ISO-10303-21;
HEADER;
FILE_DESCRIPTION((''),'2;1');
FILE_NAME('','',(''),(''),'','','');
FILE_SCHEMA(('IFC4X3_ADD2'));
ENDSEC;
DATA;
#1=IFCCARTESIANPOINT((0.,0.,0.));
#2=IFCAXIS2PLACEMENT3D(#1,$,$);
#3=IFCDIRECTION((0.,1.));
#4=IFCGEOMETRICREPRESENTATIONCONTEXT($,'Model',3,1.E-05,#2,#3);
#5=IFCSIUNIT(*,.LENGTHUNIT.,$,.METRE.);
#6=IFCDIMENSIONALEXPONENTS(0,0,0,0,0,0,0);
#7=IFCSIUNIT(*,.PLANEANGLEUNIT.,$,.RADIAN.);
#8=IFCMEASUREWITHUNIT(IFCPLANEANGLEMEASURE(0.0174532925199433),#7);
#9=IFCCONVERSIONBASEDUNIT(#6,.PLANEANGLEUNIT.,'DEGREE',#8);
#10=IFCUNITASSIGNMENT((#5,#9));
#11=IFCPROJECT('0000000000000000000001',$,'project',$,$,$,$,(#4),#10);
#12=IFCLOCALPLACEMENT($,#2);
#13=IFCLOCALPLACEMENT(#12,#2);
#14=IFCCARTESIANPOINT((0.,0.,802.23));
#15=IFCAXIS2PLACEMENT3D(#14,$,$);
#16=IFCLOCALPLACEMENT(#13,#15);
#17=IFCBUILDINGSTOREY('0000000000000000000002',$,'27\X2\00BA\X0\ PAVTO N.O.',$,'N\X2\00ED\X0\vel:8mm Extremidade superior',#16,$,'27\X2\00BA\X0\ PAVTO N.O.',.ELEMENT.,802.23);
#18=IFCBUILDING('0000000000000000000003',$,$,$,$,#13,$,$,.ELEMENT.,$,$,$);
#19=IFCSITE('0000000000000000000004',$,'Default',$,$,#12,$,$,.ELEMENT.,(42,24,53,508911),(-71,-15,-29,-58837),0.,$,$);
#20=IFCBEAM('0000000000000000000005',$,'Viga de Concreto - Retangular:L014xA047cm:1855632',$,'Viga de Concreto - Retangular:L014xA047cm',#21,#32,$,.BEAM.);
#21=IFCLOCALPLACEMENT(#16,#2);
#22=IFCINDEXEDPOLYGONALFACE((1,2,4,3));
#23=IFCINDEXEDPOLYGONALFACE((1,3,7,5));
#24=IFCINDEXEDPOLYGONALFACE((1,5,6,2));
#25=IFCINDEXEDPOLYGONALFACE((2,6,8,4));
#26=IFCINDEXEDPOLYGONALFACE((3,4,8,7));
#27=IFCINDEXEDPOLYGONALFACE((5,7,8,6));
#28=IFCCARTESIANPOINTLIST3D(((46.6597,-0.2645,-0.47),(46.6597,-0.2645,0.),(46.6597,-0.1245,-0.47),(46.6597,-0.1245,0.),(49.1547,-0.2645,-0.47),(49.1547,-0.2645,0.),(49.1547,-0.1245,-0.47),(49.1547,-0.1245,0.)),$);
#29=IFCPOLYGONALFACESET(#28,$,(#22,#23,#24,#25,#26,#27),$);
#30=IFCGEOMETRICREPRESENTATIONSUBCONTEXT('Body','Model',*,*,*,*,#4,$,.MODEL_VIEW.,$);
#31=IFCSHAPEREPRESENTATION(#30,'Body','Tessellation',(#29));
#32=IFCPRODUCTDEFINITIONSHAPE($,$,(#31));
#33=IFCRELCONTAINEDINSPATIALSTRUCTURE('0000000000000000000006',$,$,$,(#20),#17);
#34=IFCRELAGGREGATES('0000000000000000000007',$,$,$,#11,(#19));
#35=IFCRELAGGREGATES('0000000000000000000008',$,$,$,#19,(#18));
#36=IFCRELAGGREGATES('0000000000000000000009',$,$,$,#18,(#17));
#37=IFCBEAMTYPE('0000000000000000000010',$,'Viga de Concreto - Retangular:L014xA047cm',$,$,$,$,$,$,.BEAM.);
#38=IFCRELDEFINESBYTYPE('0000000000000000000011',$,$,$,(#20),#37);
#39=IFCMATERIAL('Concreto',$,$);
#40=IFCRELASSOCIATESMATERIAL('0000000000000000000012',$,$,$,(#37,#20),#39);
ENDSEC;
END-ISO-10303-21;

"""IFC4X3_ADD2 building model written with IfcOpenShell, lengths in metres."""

from ifc_helpers import new_model, entity, si_unit, converted_unit, direction, frame, frame_2d, origin, place, context, subcontext, project, spatial, rectangle, extrude, source, transform, mapped, material, material_profile, profile_set, profile_usage, type_object, type_shapes, element, save


model = new_model("IFC4X3_ADD2")

# Units and contexts
model_context = context("Model", 3, precision=1e-05, world=origin(), true_north=direction((0.0, 1.0)))
body_context = subcontext(model_context, "Body", "Model", "MODEL_VIEW")
ifc_project = project(units=[si_unit("LENGTHUNIT", "METRE"), converted_unit("PLANEANGLEUNIT", "DEGREE", entity("IfcPlaneAngleMeasure", 0.0174532925199433), si_unit("PLANEANGLEUNIT", "RADIAN"), dimensions=[0, 0, 0, 0, 0, 0, 0])], contexts=[model_context])

# Site, building, storey
site_placement = place(None, origin())
site = spatial("IfcSite", under=ifc_project, at=site_placement, Name="Default", CompositionType="ELEMENT", RefLatitude=(42, 24, 53, 508911), RefLongitude=(-71, -15, -29, -58837), RefElevation=0.0)
building_placement = place(site_placement, origin())
building = spatial("IfcBuilding", under=site, at=building_placement, CompositionType="ELEMENT")
storey_placement = place(building_placement, frame((0.0, 0.0, 802.23)))
storey = spatial("IfcBuildingStorey", under=building, at=storey_placement, Name="27º PAVTO N.O.", ObjectType="Nível:8mm Extremidade superior", LongName="27º PAVTO N.O.", CompositionType="ELEMENT", Elevation=802.23)

# Beam
ifc_material = material(Name="Concreto")
ifc_material_profile_1 = material_profile(ifc_material, rectangle(XDim=0.47, YDim=0.14, at=frame_2d((0.0, 0.0), x_axis=(0.0, 1.0))), Name="L014xA047cm")
ifc_profile_set_1 = profile_set([ifc_material_profile_1], Name="L014xA047cm")
ifc_profile_usage_1 = profile_usage(ifc_profile_set_1, cardinal=8)
beam_type_1 = type_object("IfcBeamType", Name="Viga de Concreto - Retangular:L014xA047cm", PredefinedType="BEAM", material=ifc_profile_set_1)
shared_shape_1 = source(origin(), body_context, "Body", "SweptSolid", [
    extrude(rectangle(XDim=0.47, YDim=0.14, at=frame_2d((0.0, 0.0), x_axis=(1.0, 0.0))), frame((46.6597, -0.1945, 801.995), z_axis=(1.0, 0.0, 0.0), x_axis=(0.0, 0.0, -1.0)), (0.0, 0.0, 1.0), 2.495),
])
type_shapes(beam_type_1, [shared_shape_1])
beam_1_placement = place(storey_placement, frame((0.0, 0.0, -802.23)))
element("IfcBeam", 1, at=beam_1_placement, inside=storey, type_object=beam_type_1, material=ifc_profile_usage_1, Name="Viga de Concreto - Retangular:L014xA047cm:1855632", ObjectType="Viga de Concreto - Retangular:L014xA047cm", PredefinedType="BEAM", context=body_context, shape_type="MappedRepresentation", body=[
    mapped(shared_shape_1, transform((0.0, 0.0, 0.0), scale=1.0)),
])

save(model, "model.ifc")
